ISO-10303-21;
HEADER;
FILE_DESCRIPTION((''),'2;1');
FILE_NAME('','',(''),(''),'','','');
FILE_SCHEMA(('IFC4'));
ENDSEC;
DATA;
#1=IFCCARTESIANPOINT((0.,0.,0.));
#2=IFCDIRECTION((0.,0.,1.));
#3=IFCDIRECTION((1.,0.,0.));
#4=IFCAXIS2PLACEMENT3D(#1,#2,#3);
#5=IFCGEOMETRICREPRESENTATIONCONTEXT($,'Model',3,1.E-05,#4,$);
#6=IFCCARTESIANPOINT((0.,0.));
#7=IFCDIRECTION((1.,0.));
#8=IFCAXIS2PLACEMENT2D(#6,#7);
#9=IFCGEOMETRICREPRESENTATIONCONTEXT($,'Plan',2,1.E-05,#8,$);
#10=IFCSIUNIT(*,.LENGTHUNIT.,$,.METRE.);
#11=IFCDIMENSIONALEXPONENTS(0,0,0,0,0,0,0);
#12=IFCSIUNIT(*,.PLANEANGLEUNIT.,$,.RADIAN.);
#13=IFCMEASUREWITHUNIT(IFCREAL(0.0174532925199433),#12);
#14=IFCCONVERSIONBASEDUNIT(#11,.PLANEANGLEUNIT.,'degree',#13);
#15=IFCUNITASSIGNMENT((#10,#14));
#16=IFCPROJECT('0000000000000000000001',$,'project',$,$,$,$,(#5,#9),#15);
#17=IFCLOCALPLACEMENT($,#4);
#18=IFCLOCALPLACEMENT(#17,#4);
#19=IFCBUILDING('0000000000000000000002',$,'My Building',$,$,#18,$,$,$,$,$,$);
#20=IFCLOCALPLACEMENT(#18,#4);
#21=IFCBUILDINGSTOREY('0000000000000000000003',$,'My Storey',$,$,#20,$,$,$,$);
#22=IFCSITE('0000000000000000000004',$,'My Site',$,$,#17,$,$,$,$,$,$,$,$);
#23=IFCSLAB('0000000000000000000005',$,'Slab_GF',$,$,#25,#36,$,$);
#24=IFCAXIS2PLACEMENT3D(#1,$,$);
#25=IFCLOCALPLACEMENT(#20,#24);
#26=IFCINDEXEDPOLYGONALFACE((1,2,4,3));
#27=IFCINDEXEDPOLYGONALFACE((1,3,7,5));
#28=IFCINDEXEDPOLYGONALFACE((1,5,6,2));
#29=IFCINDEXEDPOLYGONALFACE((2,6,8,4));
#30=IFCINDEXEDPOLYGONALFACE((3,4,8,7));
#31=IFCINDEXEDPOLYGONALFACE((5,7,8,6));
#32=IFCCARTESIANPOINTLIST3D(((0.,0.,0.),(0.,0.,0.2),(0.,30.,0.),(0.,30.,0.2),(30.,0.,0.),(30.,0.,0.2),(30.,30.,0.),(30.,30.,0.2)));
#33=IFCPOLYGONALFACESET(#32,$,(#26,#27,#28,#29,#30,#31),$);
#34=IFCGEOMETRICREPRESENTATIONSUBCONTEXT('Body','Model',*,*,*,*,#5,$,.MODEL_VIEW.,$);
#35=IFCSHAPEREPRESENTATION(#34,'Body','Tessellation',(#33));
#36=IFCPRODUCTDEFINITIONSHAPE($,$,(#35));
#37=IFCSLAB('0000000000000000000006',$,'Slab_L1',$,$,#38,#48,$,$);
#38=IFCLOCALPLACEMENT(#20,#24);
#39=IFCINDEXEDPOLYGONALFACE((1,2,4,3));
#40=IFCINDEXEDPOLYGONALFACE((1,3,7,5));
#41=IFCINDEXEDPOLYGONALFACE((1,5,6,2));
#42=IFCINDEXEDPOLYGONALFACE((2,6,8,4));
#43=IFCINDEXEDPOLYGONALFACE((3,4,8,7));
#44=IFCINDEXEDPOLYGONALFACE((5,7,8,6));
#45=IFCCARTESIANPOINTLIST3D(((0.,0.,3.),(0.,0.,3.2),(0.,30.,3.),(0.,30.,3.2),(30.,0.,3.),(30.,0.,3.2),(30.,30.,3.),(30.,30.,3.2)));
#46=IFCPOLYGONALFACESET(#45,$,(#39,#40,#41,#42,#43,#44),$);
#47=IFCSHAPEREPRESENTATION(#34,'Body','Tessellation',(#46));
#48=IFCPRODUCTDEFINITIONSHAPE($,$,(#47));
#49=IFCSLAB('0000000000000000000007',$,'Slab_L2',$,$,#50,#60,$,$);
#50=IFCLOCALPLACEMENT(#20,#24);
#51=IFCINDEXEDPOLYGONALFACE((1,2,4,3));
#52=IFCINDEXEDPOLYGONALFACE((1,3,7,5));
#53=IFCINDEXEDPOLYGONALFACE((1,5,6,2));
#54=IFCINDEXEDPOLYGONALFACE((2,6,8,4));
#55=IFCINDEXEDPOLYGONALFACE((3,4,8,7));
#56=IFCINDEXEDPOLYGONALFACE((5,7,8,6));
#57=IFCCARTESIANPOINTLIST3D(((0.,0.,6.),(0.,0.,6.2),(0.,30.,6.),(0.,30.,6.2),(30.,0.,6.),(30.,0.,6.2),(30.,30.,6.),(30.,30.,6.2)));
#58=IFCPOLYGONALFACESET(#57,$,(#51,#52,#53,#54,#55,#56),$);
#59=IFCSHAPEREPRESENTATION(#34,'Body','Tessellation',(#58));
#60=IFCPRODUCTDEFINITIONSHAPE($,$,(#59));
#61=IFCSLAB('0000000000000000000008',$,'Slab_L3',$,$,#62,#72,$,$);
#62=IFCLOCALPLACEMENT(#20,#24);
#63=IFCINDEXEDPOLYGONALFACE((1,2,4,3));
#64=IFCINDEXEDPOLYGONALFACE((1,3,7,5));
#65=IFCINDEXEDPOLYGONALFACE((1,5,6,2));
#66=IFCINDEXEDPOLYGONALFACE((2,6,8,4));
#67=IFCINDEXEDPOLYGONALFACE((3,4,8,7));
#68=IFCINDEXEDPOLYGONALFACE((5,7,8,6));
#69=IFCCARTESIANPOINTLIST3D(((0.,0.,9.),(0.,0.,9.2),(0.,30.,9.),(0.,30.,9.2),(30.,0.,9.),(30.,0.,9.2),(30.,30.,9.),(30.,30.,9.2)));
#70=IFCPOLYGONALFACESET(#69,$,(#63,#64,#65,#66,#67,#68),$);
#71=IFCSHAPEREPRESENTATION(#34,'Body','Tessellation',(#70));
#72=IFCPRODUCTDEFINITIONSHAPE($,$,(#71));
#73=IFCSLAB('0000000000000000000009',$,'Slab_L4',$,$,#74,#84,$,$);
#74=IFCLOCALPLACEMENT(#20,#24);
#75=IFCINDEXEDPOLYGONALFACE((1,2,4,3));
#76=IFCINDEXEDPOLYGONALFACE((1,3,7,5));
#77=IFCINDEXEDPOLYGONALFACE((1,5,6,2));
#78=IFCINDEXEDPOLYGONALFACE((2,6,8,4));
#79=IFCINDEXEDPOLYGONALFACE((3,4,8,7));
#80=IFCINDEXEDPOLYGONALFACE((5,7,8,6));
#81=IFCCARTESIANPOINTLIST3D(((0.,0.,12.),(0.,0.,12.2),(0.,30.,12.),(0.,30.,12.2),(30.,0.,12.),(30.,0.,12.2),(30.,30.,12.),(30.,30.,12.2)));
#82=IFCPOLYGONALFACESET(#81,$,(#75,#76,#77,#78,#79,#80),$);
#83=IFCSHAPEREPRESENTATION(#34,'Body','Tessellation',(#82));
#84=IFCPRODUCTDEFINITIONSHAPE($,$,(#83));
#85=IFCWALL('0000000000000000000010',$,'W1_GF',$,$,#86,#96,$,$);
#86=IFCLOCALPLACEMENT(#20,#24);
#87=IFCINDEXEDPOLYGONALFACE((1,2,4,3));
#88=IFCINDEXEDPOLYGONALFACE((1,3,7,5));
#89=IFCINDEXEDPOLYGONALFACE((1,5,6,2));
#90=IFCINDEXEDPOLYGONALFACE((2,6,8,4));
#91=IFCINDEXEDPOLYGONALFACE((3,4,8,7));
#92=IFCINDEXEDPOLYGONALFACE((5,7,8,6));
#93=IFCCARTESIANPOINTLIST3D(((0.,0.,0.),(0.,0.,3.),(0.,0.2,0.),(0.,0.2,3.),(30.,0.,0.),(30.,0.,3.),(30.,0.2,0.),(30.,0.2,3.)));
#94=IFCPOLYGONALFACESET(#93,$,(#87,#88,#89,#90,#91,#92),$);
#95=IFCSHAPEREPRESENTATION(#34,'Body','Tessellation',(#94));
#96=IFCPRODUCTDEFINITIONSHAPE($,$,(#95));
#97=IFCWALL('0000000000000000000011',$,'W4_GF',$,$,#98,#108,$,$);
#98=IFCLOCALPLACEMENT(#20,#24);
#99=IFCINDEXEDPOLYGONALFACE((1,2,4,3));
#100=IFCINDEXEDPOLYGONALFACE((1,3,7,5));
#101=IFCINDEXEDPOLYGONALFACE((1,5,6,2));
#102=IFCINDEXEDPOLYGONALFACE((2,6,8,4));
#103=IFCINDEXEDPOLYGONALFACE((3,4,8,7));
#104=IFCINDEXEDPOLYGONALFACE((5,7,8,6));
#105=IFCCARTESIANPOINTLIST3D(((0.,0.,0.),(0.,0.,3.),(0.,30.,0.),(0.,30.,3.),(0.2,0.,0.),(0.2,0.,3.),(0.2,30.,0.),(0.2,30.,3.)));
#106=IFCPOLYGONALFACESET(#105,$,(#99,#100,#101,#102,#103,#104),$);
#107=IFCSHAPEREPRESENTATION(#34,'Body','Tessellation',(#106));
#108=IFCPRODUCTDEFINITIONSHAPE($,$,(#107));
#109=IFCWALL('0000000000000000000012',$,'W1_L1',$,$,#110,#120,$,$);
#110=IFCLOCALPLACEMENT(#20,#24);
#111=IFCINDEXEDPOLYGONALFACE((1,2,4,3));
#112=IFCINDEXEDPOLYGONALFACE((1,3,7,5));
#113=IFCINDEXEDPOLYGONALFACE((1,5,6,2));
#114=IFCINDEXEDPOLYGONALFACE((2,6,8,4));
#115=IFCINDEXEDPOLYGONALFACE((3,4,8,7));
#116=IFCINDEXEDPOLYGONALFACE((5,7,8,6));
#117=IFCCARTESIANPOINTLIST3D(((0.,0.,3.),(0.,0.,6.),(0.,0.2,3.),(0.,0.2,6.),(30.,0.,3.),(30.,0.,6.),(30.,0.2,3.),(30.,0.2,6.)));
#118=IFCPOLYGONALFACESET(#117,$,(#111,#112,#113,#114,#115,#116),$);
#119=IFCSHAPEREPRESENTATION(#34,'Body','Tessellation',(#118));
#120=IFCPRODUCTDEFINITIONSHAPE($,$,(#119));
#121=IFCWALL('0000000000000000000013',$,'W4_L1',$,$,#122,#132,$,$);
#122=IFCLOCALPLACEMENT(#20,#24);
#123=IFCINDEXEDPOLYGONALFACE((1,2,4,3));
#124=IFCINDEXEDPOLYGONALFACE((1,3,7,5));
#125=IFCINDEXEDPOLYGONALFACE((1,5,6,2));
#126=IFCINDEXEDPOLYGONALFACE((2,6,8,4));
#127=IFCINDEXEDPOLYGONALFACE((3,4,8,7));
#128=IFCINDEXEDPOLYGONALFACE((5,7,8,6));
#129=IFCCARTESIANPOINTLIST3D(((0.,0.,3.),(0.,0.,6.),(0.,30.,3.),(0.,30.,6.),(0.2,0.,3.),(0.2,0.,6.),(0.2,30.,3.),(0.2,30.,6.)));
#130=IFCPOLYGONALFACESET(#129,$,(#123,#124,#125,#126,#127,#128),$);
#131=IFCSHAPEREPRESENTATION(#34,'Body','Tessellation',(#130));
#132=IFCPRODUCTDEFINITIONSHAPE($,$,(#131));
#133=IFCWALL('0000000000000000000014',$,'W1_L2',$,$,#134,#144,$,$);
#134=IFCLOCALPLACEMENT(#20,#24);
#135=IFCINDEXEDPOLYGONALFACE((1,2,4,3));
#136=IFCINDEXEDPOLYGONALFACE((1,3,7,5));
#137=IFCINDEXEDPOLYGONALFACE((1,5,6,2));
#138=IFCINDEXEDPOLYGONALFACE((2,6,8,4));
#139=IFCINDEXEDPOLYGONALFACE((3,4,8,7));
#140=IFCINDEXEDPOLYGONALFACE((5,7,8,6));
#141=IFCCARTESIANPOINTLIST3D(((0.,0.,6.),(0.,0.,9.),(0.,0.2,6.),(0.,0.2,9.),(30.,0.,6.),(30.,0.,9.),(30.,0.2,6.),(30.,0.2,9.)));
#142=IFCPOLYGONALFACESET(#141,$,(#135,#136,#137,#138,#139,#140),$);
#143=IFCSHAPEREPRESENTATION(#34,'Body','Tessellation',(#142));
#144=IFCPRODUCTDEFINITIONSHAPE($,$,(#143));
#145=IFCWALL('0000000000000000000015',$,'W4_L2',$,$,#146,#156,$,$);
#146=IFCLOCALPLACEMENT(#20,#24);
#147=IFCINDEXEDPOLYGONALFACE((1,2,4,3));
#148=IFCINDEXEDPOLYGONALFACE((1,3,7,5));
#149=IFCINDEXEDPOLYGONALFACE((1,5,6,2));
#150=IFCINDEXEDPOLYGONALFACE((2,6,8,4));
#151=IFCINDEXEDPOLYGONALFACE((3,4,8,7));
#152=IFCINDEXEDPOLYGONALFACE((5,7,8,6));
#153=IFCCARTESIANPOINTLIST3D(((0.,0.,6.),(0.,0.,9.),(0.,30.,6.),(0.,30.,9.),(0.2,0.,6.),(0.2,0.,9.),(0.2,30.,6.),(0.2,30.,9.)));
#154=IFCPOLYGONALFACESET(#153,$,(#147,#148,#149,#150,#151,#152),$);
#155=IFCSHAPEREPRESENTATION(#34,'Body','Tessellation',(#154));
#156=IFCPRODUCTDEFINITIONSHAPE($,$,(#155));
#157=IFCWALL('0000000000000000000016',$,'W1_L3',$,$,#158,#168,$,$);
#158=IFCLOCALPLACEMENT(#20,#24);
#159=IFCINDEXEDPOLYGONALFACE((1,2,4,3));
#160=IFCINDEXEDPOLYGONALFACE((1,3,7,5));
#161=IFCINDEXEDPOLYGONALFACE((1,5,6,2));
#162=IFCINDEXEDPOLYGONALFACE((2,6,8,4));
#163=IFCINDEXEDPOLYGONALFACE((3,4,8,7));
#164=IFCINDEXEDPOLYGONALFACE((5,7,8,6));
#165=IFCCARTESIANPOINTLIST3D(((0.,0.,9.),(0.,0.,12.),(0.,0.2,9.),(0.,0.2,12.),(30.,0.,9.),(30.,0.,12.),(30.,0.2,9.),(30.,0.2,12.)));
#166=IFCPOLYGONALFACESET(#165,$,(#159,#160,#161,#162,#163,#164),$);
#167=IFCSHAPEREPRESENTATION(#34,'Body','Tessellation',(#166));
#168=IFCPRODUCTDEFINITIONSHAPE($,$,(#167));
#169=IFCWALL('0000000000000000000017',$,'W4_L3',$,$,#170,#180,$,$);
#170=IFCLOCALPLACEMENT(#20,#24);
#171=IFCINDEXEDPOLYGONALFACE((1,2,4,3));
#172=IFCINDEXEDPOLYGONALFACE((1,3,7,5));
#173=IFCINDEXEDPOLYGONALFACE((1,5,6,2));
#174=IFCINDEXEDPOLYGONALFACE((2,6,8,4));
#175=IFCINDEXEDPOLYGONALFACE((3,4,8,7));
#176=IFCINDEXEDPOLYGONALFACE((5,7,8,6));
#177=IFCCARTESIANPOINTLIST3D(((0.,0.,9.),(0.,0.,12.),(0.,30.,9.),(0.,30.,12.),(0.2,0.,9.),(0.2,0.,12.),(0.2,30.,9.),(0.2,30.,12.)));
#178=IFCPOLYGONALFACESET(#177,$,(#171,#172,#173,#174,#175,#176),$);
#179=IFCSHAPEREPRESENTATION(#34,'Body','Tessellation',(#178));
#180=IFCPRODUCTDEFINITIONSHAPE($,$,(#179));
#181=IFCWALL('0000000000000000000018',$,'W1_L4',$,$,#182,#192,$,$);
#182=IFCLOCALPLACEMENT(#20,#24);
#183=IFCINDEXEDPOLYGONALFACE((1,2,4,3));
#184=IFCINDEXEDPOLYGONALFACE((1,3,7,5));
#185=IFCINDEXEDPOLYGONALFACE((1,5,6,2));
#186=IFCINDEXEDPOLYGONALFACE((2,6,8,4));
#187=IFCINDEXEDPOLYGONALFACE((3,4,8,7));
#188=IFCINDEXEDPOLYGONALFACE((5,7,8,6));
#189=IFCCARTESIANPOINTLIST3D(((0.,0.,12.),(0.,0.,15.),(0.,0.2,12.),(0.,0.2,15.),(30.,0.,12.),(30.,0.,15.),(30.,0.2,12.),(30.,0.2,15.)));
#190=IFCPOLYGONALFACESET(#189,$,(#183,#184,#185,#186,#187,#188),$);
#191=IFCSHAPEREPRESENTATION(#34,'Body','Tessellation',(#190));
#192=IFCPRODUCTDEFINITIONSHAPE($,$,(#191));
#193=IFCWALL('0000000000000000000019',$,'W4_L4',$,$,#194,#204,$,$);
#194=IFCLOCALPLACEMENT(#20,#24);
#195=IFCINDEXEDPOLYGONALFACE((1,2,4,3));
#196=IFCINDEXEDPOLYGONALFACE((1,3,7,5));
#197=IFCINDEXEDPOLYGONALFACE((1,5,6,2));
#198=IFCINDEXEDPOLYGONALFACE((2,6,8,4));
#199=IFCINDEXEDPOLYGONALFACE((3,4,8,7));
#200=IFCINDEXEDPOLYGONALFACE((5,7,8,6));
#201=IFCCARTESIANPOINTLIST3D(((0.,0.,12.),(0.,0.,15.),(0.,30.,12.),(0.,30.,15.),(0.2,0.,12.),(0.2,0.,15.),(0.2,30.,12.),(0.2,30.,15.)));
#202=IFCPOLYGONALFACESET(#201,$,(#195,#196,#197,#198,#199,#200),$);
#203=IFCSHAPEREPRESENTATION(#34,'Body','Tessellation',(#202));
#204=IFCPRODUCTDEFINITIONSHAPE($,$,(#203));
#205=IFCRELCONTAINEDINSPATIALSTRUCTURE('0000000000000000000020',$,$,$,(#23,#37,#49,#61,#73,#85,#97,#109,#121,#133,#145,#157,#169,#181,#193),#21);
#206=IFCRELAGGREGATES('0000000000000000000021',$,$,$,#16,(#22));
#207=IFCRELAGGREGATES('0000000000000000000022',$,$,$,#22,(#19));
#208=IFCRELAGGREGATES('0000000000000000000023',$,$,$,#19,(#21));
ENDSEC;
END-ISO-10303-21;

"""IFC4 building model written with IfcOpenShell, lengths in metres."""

from ifc_helpers import new_model, entity, si_unit, converted_unit, frame, origin_with_axes, origin_2d_with_axis, place, context, subcontext, project, spatial, indexed_curve, outline, extrude, element, save


model = new_model("IFC4")

# Units and contexts
model_context = context("Model", 3, precision=1e-05, world=origin_with_axes())
plan_context = context("Plan", 2, precision=1e-05, world=origin_2d_with_axis())
body_context = subcontext(model_context, "Body", "Model", "MODEL_VIEW")
ifc_project = project(units=[si_unit("LENGTHUNIT", "METRE"), converted_unit("PLANEANGLEUNIT", "degree", entity("IfcReal", 0.0174532925199433), si_unit("PLANEANGLEUNIT", "RADIAN"), dimensions=[0, 0, 0, 0, 0, 0, 0])], contexts=[model_context, plan_context])

# Site, building, storey
site_placement = place(None, origin_with_axes())
site = spatial("IfcSite", under=ifc_project, at=site_placement, Name="My Site")
building_placement = place(site_placement, origin_with_axes())
building = spatial("IfcBuilding", under=site, at=building_placement, Name="My Building")
storey_placement = place(building_placement, origin_with_axes())
storey = spatial("IfcBuildingStorey", under=building, at=storey_placement, Name="My Storey")

# Slabs
for number, where, z_axis, x_axis, name in (
    (1, (0.0, 0.0, 0.0), (0.0, 0.0, 1.0), (1.0, 0.0, 0.0), "Slab_GF"),
    (2, (0.0, 0.0, 3.0), (0.0, 0.0, 1.0), (1.0, 0.0, 0.0), "Slab_L1"),
    (3, (0.0, 0.0, 6.0), (0.0, 0.0, 1.0), (1.0, 0.0, 0.0), "Slab_L2"),
    (4, (0.0, 0.0, 9.0), (0.0, 0.0, 1.0), (1.0, 0.0, 0.0), "Slab_L3"),
    (5, (0.0, 0.0, 12.0), (0.0, 0.0, 1.0), (1.0, 0.0, 0.0), "Slab_L4"),
):
    element("IfcSlab", number, at=place(storey_placement, frame(where, z_axis=z_axis, x_axis=x_axis)), inside=storey, Name=name, context=body_context, shape_type="SweptSolid", body=[
        extrude(outline(indexed_curve([(0.0, 0.0), (30.0, 0.0), (30.0, 30.0), (0.0, 30.0), (0.0, 0.0)])), None, (0.0, 0.0, 1.0), 0.2),
    ])

# Walls
for number, where, z_axis, x_axis, name in (
    (6, (0.0, 0.0, 0.0), (0.0, 0.0, 1.0), (1.0, 0.0, 0.0), "W1_GF"),
    (7, (0.0, 30.0, 0.0), (0.0, 0.0, 1.0), (0.0, -1.0, 0.0), "W4_GF"),
    (8, (0.0, 0.0, 3.0), (0.0, 0.0, 1.0), (1.0, 0.0, 0.0), "W1_L1"),
    (9, (0.0, 30.0, 3.0), (0.0, 0.0, 1.0), (0.0, -1.0, 0.0), "W4_L1"),
    (10, (0.0, 0.0, 6.0), (0.0, 0.0, 1.0), (1.0, 0.0, 0.0), "W1_L2"),
    (11, (0.0, 30.0, 6.0), (0.0, 0.0, 1.0), (0.0, -1.0, 0.0), "W4_L2"),
    (12, (0.0, 0.0, 9.0), (0.0, 0.0, 1.0), (1.0, 0.0, 0.0), "W1_L3"),
    (13, (0.0, 30.0, 9.0), (0.0, 0.0, 1.0), (0.0, -1.0, 0.0), "W4_L3"),
    (14, (0.0, 0.0, 12.0), (0.0, 0.0, 1.0), (1.0, 0.0, 0.0), "W1_L4"),
    (15, (0.0, 30.0, 12.0), (0.0, 0.0, 1.0), (0.0, -1.0, 0.0), "W4_L4"),
):
    element("IfcWall", number, at=place(storey_placement, frame(where, z_axis=z_axis, x_axis=x_axis)), inside=storey, Name=name, context=body_context, shape_type="SweptSolid", body=[
        extrude(outline(indexed_curve([(0.0, 0.0), (0.0, 0.2), (30.0, 0.2), (30.0, 0.0), (0.0, 0.0)], self_intersect=False)), origin_with_axes(), (0.0, 0.0, 1.0), 3.0),
    ])

save(model, "model.ifc")
